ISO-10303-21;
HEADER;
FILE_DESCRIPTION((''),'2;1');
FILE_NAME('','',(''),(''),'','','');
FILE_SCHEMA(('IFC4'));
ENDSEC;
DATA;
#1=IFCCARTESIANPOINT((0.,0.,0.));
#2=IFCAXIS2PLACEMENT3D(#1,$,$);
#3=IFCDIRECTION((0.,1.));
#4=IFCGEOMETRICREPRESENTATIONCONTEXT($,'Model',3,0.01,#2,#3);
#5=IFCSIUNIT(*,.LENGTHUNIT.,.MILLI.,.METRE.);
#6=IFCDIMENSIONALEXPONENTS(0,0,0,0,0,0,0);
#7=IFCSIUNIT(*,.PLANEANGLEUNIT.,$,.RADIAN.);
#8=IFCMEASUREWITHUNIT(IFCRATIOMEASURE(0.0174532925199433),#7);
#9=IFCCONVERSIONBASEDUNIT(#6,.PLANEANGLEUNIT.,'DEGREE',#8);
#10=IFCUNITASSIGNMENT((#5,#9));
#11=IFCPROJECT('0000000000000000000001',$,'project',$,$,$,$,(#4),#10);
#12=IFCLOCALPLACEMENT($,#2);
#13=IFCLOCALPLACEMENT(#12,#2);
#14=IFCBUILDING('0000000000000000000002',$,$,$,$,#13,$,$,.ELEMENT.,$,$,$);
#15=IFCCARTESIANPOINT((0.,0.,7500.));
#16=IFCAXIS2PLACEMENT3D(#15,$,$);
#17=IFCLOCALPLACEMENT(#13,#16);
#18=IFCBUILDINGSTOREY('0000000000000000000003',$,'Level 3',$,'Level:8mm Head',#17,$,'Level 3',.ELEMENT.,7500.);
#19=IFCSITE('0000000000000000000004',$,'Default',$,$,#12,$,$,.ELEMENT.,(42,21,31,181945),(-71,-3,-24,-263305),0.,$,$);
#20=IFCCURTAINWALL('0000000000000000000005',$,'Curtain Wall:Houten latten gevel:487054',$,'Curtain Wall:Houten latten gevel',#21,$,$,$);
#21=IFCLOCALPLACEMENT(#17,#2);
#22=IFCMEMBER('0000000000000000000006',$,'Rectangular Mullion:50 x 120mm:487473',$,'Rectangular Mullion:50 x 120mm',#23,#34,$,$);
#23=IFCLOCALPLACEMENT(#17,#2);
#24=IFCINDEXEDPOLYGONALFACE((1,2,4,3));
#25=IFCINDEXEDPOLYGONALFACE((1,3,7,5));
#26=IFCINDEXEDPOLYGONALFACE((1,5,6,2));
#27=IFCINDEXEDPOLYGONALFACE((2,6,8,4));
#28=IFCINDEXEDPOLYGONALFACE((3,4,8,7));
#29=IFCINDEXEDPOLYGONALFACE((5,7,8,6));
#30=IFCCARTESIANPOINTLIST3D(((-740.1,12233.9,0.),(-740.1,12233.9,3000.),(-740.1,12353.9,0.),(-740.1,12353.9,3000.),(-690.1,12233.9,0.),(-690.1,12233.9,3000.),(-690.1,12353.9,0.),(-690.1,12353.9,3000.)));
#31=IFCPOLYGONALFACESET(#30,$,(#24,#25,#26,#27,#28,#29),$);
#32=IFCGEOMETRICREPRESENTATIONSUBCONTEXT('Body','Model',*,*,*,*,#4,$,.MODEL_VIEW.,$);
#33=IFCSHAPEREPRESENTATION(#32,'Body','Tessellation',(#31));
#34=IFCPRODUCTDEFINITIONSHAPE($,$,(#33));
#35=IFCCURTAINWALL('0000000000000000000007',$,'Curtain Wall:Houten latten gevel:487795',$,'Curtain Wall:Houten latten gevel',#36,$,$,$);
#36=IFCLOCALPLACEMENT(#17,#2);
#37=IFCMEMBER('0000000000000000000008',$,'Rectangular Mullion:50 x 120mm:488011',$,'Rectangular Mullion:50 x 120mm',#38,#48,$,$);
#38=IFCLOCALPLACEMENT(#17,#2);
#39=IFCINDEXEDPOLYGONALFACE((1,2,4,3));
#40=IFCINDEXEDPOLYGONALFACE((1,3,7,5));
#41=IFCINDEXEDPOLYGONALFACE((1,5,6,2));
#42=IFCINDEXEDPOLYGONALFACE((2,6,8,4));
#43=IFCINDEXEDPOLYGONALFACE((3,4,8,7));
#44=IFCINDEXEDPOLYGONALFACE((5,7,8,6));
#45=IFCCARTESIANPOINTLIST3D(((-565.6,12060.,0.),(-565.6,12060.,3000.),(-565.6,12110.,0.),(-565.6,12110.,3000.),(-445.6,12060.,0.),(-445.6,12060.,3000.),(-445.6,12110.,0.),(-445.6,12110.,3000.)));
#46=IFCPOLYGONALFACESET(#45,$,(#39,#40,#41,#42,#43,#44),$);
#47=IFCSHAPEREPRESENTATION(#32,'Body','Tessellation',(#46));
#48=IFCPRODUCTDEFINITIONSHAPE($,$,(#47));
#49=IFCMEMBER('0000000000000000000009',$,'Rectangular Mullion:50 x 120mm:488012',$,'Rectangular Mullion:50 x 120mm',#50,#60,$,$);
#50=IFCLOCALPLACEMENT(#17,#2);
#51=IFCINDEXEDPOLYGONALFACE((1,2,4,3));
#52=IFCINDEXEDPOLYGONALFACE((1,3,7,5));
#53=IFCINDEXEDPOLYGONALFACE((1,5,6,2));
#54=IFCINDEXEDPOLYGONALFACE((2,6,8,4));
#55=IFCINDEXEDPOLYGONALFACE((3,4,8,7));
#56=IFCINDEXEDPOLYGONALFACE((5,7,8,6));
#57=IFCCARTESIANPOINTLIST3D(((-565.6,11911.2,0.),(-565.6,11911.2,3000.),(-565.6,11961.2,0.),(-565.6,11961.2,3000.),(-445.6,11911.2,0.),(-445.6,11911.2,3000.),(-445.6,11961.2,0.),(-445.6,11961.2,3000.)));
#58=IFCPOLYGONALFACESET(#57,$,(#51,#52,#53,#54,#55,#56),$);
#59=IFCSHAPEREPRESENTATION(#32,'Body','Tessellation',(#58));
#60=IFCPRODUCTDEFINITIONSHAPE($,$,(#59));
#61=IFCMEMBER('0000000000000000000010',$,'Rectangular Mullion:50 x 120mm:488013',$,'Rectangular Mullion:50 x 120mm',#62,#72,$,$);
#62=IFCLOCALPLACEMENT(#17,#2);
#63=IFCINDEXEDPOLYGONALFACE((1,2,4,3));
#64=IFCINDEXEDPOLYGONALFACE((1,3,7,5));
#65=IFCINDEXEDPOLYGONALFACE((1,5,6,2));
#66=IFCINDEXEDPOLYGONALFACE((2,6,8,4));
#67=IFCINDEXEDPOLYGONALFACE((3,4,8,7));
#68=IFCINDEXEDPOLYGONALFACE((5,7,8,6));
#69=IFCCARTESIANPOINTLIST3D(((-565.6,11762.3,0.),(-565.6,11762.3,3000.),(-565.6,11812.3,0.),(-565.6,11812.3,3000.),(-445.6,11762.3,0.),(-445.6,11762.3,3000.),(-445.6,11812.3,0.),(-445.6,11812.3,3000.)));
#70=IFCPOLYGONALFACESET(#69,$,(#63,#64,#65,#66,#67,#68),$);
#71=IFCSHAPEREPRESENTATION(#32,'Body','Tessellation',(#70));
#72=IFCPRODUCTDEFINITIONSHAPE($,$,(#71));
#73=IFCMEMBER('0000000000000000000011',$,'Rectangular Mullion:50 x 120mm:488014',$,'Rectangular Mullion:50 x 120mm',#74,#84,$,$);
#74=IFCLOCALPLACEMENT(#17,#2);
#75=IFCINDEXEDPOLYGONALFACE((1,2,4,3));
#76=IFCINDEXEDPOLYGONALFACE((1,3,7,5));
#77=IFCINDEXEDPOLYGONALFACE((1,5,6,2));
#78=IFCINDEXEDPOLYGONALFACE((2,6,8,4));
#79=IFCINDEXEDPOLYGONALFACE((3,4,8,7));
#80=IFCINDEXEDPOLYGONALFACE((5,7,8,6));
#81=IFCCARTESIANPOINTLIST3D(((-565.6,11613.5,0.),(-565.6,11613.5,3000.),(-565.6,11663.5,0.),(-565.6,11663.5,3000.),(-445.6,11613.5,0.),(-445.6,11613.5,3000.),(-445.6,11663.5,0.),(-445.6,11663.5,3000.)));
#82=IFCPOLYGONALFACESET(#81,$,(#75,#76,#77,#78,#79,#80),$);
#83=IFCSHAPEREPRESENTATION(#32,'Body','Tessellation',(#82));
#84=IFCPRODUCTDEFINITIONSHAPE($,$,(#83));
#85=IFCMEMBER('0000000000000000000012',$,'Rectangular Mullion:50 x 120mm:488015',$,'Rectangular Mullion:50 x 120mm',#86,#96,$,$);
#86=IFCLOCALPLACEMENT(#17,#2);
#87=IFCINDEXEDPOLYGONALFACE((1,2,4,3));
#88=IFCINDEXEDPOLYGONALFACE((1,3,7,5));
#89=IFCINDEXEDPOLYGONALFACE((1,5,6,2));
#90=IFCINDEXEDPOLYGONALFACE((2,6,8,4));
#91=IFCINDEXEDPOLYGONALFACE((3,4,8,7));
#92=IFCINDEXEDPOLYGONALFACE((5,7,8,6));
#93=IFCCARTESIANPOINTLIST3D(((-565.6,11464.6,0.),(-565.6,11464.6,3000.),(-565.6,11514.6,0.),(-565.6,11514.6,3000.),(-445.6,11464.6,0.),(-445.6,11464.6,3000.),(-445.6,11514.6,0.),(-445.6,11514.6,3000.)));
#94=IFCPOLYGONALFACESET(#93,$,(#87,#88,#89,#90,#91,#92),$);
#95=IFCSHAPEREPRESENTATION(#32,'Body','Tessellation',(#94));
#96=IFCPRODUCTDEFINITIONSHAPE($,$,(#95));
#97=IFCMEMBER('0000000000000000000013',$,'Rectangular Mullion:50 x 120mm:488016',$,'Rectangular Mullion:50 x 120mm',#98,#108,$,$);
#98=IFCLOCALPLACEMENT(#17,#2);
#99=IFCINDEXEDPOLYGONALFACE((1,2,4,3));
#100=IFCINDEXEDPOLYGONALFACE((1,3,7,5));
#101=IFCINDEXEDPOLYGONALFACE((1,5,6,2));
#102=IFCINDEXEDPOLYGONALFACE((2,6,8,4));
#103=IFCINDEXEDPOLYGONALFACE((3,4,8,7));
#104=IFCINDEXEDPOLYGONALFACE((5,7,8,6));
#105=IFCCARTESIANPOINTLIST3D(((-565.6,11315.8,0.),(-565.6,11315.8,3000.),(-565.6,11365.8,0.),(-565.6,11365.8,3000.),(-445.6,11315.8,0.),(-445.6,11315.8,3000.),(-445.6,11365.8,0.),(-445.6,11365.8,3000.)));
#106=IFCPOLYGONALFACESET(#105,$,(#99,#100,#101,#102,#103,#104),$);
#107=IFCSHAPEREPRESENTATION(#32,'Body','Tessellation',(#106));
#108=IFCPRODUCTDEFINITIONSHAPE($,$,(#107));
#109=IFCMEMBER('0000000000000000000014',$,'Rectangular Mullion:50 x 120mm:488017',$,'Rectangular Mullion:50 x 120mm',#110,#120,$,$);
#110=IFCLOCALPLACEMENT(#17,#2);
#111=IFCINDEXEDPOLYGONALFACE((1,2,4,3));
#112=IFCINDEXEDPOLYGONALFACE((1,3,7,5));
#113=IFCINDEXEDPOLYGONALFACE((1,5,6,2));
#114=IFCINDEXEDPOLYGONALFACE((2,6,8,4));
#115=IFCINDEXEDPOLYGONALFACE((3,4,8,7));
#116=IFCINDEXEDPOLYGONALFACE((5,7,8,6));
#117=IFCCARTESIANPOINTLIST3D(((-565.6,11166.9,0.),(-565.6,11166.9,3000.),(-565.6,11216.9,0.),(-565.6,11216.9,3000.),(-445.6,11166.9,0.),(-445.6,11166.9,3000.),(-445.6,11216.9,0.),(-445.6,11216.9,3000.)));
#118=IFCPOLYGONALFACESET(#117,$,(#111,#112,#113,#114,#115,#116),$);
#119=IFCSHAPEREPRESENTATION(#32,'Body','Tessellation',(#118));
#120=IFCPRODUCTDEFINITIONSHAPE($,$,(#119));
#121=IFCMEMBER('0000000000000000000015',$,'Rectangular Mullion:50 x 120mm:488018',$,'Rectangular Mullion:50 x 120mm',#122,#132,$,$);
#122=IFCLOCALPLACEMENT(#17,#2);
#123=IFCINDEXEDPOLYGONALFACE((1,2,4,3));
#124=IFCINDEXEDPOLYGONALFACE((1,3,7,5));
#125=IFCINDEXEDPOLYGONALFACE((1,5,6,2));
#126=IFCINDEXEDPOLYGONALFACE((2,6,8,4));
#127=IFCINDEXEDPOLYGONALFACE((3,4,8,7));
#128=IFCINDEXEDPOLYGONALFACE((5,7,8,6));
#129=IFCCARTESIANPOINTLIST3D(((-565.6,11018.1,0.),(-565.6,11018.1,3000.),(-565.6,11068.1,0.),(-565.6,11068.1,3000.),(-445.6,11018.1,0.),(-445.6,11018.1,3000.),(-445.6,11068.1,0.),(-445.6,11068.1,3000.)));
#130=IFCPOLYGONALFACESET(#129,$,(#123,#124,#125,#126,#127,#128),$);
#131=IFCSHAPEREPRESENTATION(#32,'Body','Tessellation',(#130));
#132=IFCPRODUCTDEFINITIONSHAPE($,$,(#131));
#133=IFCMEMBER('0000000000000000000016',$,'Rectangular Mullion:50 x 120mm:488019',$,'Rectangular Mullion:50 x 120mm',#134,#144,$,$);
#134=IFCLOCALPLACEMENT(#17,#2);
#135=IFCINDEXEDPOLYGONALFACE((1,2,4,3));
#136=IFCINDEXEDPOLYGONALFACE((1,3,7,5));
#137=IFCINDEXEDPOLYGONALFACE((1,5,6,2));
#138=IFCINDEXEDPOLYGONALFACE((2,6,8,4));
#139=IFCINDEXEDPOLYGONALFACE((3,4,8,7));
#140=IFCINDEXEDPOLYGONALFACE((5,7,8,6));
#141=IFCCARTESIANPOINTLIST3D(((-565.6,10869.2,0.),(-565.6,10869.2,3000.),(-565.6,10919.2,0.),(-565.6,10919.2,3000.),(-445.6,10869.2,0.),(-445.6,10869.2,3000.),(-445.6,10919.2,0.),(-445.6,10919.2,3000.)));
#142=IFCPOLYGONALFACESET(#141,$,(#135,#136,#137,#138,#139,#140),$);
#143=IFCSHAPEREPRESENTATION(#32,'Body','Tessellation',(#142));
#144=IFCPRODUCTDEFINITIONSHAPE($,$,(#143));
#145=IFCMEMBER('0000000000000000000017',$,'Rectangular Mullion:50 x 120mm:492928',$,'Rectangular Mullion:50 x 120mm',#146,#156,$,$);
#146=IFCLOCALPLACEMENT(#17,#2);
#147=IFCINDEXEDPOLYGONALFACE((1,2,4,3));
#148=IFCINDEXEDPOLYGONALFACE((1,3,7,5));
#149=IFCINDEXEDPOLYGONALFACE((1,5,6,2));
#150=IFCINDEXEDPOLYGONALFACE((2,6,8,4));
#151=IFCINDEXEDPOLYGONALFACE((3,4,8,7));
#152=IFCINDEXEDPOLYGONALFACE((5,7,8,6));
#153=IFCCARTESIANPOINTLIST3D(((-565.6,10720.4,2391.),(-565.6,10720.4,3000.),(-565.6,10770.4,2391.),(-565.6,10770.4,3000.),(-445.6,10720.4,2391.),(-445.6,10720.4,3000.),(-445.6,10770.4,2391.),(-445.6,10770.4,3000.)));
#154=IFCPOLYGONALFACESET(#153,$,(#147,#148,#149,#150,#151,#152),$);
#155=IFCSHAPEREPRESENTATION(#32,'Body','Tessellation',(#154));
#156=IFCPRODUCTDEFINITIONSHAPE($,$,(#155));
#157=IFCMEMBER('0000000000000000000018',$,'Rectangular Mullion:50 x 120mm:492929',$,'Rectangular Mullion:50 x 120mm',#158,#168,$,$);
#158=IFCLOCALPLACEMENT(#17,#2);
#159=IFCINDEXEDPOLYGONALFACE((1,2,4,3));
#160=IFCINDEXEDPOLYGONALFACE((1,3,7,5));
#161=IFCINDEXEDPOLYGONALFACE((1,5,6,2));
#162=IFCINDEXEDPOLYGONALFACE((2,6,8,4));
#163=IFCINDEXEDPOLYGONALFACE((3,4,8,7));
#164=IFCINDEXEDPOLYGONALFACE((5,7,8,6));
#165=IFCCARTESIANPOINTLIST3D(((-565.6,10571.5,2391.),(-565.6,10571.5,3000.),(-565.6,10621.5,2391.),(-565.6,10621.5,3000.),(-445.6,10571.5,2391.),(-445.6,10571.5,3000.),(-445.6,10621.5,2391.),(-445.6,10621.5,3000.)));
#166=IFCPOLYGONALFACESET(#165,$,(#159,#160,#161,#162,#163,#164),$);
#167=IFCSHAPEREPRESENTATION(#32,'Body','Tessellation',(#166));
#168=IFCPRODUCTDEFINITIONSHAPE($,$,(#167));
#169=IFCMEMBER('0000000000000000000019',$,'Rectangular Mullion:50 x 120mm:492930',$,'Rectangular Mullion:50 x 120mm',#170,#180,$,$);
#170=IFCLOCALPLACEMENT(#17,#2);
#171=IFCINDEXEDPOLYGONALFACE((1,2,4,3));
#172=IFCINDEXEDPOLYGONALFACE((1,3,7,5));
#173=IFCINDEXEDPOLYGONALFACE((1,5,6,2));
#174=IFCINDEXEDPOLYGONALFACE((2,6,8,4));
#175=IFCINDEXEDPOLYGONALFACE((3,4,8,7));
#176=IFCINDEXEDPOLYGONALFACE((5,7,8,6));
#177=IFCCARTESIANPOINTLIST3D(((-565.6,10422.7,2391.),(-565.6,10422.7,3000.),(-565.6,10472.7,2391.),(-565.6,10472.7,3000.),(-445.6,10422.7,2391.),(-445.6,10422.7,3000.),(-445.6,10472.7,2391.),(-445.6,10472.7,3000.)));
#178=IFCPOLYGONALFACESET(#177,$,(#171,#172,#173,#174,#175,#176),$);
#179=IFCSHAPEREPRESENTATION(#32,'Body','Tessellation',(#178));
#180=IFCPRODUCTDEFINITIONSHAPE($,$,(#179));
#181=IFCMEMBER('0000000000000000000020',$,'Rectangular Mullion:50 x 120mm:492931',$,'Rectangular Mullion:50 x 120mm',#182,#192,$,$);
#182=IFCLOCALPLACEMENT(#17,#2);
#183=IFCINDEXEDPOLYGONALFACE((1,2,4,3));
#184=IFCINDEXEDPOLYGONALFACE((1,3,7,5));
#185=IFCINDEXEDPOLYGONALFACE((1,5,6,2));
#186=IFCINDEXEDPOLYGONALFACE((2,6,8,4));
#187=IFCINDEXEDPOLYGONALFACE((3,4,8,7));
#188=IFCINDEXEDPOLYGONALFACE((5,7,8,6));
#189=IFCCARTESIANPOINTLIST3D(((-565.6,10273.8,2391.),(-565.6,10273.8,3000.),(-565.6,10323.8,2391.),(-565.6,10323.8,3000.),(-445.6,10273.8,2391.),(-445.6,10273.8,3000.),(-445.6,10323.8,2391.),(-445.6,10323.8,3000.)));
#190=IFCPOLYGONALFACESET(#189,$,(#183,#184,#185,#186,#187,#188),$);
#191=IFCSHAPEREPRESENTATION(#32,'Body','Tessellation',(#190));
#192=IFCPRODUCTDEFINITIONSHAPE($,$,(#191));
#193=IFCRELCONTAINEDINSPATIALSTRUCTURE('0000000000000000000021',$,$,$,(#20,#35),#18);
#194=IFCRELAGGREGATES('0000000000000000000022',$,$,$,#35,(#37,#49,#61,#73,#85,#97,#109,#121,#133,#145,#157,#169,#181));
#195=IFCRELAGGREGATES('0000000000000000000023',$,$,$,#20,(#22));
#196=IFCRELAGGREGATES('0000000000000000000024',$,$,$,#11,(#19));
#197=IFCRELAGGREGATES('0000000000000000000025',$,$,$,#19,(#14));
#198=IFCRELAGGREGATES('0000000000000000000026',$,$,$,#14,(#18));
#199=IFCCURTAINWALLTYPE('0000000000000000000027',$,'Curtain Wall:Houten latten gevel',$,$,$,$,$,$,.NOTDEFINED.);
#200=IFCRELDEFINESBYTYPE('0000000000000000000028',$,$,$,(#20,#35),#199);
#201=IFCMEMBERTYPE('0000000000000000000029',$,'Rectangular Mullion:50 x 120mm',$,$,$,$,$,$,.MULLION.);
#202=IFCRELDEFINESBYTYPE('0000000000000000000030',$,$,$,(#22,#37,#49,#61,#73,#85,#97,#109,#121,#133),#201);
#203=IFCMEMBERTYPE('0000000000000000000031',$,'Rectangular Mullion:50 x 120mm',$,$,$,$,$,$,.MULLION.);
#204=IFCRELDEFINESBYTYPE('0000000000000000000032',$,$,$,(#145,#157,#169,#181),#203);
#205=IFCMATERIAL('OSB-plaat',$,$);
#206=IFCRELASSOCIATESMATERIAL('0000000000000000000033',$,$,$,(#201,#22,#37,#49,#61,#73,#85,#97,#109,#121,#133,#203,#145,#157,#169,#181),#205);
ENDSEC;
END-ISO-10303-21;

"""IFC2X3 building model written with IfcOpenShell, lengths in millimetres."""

from ifc_helpers import new_model, entity, si_unit, converted_unit, direction, frame, origin, origin_2d_with_axis, place, context, subcontext, project, spatial, rectangle, extrude, source, transform, mapped, material, type_object, type_shapes, element, aggregate, save


model = new_model("IFC2X3")

# Units and contexts
model_context = context("Model", 3, precision=0.01, world=origin(), true_north=direction((0.0, 1.0)))
body_context = subcontext(model_context, "Body", "Model", "MODEL_VIEW")
ifc_project = project(units=[si_unit("LENGTHUNIT", "METRE", prefix="MILLI"), converted_unit("PLANEANGLEUNIT", "DEGREE", entity("IfcRatioMeasure", 0.0174532925199433), si_unit("PLANEANGLEUNIT", "RADIAN"), dimensions=[0, 0, 0, 0, 0, 0, 0])], contexts=[model_context])

# Site, building, storey
site_placement = place(None, frame((0.0, 0.0, 0.0)))
site = spatial("IfcSite", under=ifc_project, at=site_placement, Name="Default", CompositionType="ELEMENT", RefLatitude=(42, 21, 31, 181945), RefLongitude=(-71, -3, -24, -263305), RefElevation=0.0)
building_placement = place(site_placement, origin())
building = spatial("IfcBuilding", under=site, at=building_placement, CompositionType="ELEMENT")
storey_placement = place(building_placement, frame((0.0, 0.0, 7500.0)))
storey = spatial("IfcBuildingStorey", under=building, at=storey_placement, Name="Level 3", ObjectType="Level:8mm Head", LongName="Level 3", CompositionType="ELEMENT", Elevation=7500.0)

# Curtain wall, member
curtain_wall_type = type_object("IfcCurtainWallType", Name="Curtain Wall:Houten latten gevel", PredefinedType="NOTDEFINED")
curtain_wall_1_placement = place(storey_placement, frame((0.0, 0.0, -7500.0)))
curtain_wall_1 = element("IfcCurtainWall", 1, at=curtain_wall_1_placement, inside=storey, type_object=curtain_wall_type, Name="Curtain Wall:Houten latten gevel:487054", ObjectType="Curtain Wall:Houten latten gevel")
ifc_material_1 = material(Name="OSB-plaat")
member_type_1 = type_object("IfcMemberType", Name="Rectangular Mullion:50 x 120mm", PredefinedType="MULLION", material=ifc_material_1)
shared_shape_1 = source(origin(), body_context, "Body", "SweptSolid", [
    extrude(rectangle(XDim=120.0, YDim=50.0, at=origin_2d_with_axis()), frame((0.0, 0.0, -3000.0), z_axis=(0.0, 0.0, 1.0), x_axis=(0.0, -1.0, 0.0)), (0.0, 0.0, 1.0), 3000.0),
])
type_shapes(member_type_1, [shared_shape_1])
member_1_placement = place(storey_placement, frame((-715.1, 12293.9, 0.0), z_axis=(0.0, 0.0, -1.0), x_axis=(1.0, 0.0, 0.0)))
member_1 = element("IfcMember", 2, at=member_1_placement, type_object=member_type_1, material=ifc_material_1, Name="Rectangular Mullion:50 x 120mm:487473", ObjectType="Rectangular Mullion:50 x 120mm", context=body_context, shape_type="MappedRepresentation", body=[
    mapped(shared_shape_1, transform((0.0, 0.0, 0.0), scale=1.0)),
])

# Curtain wall, members
curtain_wall_2_placement = place(storey_placement, frame((0.0, 0.0, -7500.0)))
curtain_wall_2 = element("IfcCurtainWall", 3, at=curtain_wall_2_placement, inside=storey, type_object=curtain_wall_type, Name="Curtain Wall:Houten latten gevel:487795", ObjectType="Curtain Wall:Houten latten gevel")
member_2_placement = place(storey_placement, frame((-505.6, 12085.0, 0.0), z_axis=(0.0, 0.0, -1.0), x_axis=(0.0, -1.0, 0.0)))
member_2 = element("IfcMember", 4, at=member_2_placement, type_object=member_type_1, material=ifc_material_1, Name="Rectangular Mullion:50 x 120mm:488011", ObjectType="Rectangular Mullion:50 x 120mm", context=body_context, shape_type="MappedRepresentation", body=[
    mapped(shared_shape_1, transform((0.0, 0.0, 0.0), scale=1.0)),
])
member_3_placement = place(storey_placement, frame((-505.6, 11936.2, 0.0), z_axis=(0.0, 0.0, -1.0), x_axis=(0.0, -1.0, 0.0)))
member_3 = element("IfcMember", 5, at=member_3_placement, type_object=member_type_1, material=ifc_material_1, Name="Rectangular Mullion:50 x 120mm:488012", ObjectType="Rectangular Mullion:50 x 120mm", context=body_context, shape_type="MappedRepresentation", body=[
    mapped(shared_shape_1, transform((0.0, 0.0, 0.0), scale=1.0)),
])
member_4_placement = place(storey_placement, frame((-505.6, 11787.3, 0.0), z_axis=(0.0, 0.0, -1.0), x_axis=(0.0, -1.0, 0.0)))
member_4 = element("IfcMember", 6, at=member_4_placement, type_object=member_type_1, material=ifc_material_1, Name="Rectangular Mullion:50 x 120mm:488013", ObjectType="Rectangular Mullion:50 x 120mm", context=body_context, shape_type="MappedRepresentation", body=[
    mapped(shared_shape_1, transform((0.0, 0.0, 0.0), scale=1.0)),
])
member_5_placement = place(storey_placement, frame((-505.6, 11638.5, 0.0), z_axis=(0.0, 0.0, -1.0), x_axis=(0.0, -1.0, 0.0)))
member_5 = element("IfcMember", 7, at=member_5_placement, type_object=member_type_1, material=ifc_material_1, Name="Rectangular Mullion:50 x 120mm:488014", ObjectType="Rectangular Mullion:50 x 120mm", context=body_context, shape_type="MappedRepresentation", body=[
    mapped(shared_shape_1, transform((0.0, 0.0, 0.0), scale=1.0)),
])
member_6_placement = place(storey_placement, frame((-505.6, 11489.6, 0.0), z_axis=(0.0, 0.0, -1.0), x_axis=(0.0, -1.0, 0.0)))
member_6 = element("IfcMember", 8, at=member_6_placement, type_object=member_type_1, material=ifc_material_1, Name="Rectangular Mullion:50 x 120mm:488015", ObjectType="Rectangular Mullion:50 x 120mm", context=body_context, shape_type="MappedRepresentation", body=[
    mapped(shared_shape_1, transform((0.0, 0.0, 0.0), scale=1.0)),
])
member_7_placement = place(storey_placement, frame((-505.6, 11340.8, 0.0), z_axis=(0.0, 0.0, -1.0), x_axis=(0.0, -1.0, 0.0)))
member_7 = element("IfcMember", 9, at=member_7_placement, type_object=member_type_1, material=ifc_material_1, Name="Rectangular Mullion:50 x 120mm:488016", ObjectType="Rectangular Mullion:50 x 120mm", context=body_context, shape_type="MappedRepresentation", body=[
    mapped(shared_shape_1, transform((0.0, 0.0, 0.0), scale=1.0)),
])
member_8_placement = place(storey_placement, frame((-505.6, 11191.9, 0.0), z_axis=(0.0, 0.0, -1.0), x_axis=(0.0, -1.0, 0.0)))
member_8 = element("IfcMember", 10, at=member_8_placement, type_object=member_type_1, material=ifc_material_1, Name="Rectangular Mullion:50 x 120mm:488017", ObjectType="Rectangular Mullion:50 x 120mm", context=body_context, shape_type="MappedRepresentation", body=[
    mapped(shared_shape_1, transform((0.0, 0.0, 0.0), scale=1.0)),
])
member_9_placement = place(storey_placement, frame((-505.6, 11043.1, 0.0), z_axis=(0.0, 0.0, -1.0), x_axis=(0.0, -1.0, 0.0)))
member_9 = element("IfcMember", 11, at=member_9_placement, type_object=member_type_1, material=ifc_material_1, Name="Rectangular Mullion:50 x 120mm:488018", ObjectType="Rectangular Mullion:50 x 120mm", context=body_context, shape_type="MappedRepresentation", body=[
    mapped(shared_shape_1, transform((0.0, 0.0, 0.0), scale=1.0)),
])
member_10_placement = place(storey_placement, frame((-505.6, 10894.2, 0.0), z_axis=(0.0, 0.0, -1.0), x_axis=(0.0, -1.0, 0.0)))
member_10 = element("IfcMember", 12, at=member_10_placement, type_object=member_type_1, material=ifc_material_1, Name="Rectangular Mullion:50 x 120mm:488019", ObjectType="Rectangular Mullion:50 x 120mm", context=body_context, shape_type="MappedRepresentation", body=[
    mapped(shared_shape_1, transform((0.0, 0.0, 0.0), scale=1.0)),
])
member_type_2 = type_object("IfcMemberType", Name="Rectangular Mullion:50 x 120mm", PredefinedType="MULLION", material=ifc_material_1)
shared_shape_2 = source(origin(), body_context, "Body", "SweptSolid", [
    extrude(rectangle(XDim=120.0, YDim=50.0, at=origin_2d_with_axis()), frame((0.0, 0.0, -609.0), z_axis=(0.0, 0.0, 1.0), x_axis=(0.0, -1.0, 0.0)), (0.0, 0.0, 1.0), 609.0),
])
type_shapes(member_type_2, [shared_shape_2])
member_11_placement = place(storey_placement, frame((-505.6, 10745.4, 2391.0), z_axis=(0.0, 0.0, -1.0), x_axis=(0.0, -1.0, 0.0)))
member_11 = element("IfcMember", 13, at=member_11_placement, type_object=member_type_2, material=ifc_material_1, Name="Rectangular Mullion:50 x 120mm:492928", ObjectType="Rectangular Mullion:50 x 120mm", context=body_context, shape_type="MappedRepresentation", body=[
    mapped(shared_shape_2, transform((0.0, 0.0, 0.0), scale=1.0)),
])
member_12_placement = place(storey_placement, frame((-505.6, 10596.5, 2391.0), z_axis=(0.0, 0.0, -1.0), x_axis=(0.0, -1.0, 0.0)))
member_12 = element("IfcMember", 14, at=member_12_placement, type_object=member_type_2, material=ifc_material_1, Name="Rectangular Mullion:50 x 120mm:492929", ObjectType="Rectangular Mullion:50 x 120mm", context=body_context, shape_type="MappedRepresentation", body=[
    mapped(shared_shape_2, transform((0.0, 0.0, 0.0), scale=1.0)),
])
member_13_placement = place(storey_placement, frame((-505.6, 10447.7, 2391.0), z_axis=(0.0, 0.0, -1.0), x_axis=(0.0, -1.0, 0.0)))
member_13 = element("IfcMember", 15, at=member_13_placement, type_object=member_type_2, material=ifc_material_1, Name="Rectangular Mullion:50 x 120mm:492930", ObjectType="Rectangular Mullion:50 x 120mm", context=body_context, shape_type="MappedRepresentation", body=[
    mapped(shared_shape_2, transform((0.0, 0.0, 0.0), scale=1.0)),
])
member_14_placement = place(storey_placement, frame((-505.6, 10298.8, 2391.0), z_axis=(0.0, 0.0, -1.0), x_axis=(0.0, -1.0, 0.0)))
member_14 = element("IfcMember", 16, at=member_14_placement, type_object=member_type_2, material=ifc_material_1, Name="Rectangular Mullion:50 x 120mm:492931", ObjectType="Rectangular Mullion:50 x 120mm", context=body_context, shape_type="MappedRepresentation", body=[
    mapped(shared_shape_2, transform((0.0, 0.0, 0.0), scale=1.0)),
])
aggregate(curtain_wall_2, [member_2, member_3, member_4, member_5, member_6, member_7, member_8, member_9, member_10, member_11, member_12, member_13, member_14])

aggregate(curtain_wall_1, [member_1])

save(model, "model.ifc")
